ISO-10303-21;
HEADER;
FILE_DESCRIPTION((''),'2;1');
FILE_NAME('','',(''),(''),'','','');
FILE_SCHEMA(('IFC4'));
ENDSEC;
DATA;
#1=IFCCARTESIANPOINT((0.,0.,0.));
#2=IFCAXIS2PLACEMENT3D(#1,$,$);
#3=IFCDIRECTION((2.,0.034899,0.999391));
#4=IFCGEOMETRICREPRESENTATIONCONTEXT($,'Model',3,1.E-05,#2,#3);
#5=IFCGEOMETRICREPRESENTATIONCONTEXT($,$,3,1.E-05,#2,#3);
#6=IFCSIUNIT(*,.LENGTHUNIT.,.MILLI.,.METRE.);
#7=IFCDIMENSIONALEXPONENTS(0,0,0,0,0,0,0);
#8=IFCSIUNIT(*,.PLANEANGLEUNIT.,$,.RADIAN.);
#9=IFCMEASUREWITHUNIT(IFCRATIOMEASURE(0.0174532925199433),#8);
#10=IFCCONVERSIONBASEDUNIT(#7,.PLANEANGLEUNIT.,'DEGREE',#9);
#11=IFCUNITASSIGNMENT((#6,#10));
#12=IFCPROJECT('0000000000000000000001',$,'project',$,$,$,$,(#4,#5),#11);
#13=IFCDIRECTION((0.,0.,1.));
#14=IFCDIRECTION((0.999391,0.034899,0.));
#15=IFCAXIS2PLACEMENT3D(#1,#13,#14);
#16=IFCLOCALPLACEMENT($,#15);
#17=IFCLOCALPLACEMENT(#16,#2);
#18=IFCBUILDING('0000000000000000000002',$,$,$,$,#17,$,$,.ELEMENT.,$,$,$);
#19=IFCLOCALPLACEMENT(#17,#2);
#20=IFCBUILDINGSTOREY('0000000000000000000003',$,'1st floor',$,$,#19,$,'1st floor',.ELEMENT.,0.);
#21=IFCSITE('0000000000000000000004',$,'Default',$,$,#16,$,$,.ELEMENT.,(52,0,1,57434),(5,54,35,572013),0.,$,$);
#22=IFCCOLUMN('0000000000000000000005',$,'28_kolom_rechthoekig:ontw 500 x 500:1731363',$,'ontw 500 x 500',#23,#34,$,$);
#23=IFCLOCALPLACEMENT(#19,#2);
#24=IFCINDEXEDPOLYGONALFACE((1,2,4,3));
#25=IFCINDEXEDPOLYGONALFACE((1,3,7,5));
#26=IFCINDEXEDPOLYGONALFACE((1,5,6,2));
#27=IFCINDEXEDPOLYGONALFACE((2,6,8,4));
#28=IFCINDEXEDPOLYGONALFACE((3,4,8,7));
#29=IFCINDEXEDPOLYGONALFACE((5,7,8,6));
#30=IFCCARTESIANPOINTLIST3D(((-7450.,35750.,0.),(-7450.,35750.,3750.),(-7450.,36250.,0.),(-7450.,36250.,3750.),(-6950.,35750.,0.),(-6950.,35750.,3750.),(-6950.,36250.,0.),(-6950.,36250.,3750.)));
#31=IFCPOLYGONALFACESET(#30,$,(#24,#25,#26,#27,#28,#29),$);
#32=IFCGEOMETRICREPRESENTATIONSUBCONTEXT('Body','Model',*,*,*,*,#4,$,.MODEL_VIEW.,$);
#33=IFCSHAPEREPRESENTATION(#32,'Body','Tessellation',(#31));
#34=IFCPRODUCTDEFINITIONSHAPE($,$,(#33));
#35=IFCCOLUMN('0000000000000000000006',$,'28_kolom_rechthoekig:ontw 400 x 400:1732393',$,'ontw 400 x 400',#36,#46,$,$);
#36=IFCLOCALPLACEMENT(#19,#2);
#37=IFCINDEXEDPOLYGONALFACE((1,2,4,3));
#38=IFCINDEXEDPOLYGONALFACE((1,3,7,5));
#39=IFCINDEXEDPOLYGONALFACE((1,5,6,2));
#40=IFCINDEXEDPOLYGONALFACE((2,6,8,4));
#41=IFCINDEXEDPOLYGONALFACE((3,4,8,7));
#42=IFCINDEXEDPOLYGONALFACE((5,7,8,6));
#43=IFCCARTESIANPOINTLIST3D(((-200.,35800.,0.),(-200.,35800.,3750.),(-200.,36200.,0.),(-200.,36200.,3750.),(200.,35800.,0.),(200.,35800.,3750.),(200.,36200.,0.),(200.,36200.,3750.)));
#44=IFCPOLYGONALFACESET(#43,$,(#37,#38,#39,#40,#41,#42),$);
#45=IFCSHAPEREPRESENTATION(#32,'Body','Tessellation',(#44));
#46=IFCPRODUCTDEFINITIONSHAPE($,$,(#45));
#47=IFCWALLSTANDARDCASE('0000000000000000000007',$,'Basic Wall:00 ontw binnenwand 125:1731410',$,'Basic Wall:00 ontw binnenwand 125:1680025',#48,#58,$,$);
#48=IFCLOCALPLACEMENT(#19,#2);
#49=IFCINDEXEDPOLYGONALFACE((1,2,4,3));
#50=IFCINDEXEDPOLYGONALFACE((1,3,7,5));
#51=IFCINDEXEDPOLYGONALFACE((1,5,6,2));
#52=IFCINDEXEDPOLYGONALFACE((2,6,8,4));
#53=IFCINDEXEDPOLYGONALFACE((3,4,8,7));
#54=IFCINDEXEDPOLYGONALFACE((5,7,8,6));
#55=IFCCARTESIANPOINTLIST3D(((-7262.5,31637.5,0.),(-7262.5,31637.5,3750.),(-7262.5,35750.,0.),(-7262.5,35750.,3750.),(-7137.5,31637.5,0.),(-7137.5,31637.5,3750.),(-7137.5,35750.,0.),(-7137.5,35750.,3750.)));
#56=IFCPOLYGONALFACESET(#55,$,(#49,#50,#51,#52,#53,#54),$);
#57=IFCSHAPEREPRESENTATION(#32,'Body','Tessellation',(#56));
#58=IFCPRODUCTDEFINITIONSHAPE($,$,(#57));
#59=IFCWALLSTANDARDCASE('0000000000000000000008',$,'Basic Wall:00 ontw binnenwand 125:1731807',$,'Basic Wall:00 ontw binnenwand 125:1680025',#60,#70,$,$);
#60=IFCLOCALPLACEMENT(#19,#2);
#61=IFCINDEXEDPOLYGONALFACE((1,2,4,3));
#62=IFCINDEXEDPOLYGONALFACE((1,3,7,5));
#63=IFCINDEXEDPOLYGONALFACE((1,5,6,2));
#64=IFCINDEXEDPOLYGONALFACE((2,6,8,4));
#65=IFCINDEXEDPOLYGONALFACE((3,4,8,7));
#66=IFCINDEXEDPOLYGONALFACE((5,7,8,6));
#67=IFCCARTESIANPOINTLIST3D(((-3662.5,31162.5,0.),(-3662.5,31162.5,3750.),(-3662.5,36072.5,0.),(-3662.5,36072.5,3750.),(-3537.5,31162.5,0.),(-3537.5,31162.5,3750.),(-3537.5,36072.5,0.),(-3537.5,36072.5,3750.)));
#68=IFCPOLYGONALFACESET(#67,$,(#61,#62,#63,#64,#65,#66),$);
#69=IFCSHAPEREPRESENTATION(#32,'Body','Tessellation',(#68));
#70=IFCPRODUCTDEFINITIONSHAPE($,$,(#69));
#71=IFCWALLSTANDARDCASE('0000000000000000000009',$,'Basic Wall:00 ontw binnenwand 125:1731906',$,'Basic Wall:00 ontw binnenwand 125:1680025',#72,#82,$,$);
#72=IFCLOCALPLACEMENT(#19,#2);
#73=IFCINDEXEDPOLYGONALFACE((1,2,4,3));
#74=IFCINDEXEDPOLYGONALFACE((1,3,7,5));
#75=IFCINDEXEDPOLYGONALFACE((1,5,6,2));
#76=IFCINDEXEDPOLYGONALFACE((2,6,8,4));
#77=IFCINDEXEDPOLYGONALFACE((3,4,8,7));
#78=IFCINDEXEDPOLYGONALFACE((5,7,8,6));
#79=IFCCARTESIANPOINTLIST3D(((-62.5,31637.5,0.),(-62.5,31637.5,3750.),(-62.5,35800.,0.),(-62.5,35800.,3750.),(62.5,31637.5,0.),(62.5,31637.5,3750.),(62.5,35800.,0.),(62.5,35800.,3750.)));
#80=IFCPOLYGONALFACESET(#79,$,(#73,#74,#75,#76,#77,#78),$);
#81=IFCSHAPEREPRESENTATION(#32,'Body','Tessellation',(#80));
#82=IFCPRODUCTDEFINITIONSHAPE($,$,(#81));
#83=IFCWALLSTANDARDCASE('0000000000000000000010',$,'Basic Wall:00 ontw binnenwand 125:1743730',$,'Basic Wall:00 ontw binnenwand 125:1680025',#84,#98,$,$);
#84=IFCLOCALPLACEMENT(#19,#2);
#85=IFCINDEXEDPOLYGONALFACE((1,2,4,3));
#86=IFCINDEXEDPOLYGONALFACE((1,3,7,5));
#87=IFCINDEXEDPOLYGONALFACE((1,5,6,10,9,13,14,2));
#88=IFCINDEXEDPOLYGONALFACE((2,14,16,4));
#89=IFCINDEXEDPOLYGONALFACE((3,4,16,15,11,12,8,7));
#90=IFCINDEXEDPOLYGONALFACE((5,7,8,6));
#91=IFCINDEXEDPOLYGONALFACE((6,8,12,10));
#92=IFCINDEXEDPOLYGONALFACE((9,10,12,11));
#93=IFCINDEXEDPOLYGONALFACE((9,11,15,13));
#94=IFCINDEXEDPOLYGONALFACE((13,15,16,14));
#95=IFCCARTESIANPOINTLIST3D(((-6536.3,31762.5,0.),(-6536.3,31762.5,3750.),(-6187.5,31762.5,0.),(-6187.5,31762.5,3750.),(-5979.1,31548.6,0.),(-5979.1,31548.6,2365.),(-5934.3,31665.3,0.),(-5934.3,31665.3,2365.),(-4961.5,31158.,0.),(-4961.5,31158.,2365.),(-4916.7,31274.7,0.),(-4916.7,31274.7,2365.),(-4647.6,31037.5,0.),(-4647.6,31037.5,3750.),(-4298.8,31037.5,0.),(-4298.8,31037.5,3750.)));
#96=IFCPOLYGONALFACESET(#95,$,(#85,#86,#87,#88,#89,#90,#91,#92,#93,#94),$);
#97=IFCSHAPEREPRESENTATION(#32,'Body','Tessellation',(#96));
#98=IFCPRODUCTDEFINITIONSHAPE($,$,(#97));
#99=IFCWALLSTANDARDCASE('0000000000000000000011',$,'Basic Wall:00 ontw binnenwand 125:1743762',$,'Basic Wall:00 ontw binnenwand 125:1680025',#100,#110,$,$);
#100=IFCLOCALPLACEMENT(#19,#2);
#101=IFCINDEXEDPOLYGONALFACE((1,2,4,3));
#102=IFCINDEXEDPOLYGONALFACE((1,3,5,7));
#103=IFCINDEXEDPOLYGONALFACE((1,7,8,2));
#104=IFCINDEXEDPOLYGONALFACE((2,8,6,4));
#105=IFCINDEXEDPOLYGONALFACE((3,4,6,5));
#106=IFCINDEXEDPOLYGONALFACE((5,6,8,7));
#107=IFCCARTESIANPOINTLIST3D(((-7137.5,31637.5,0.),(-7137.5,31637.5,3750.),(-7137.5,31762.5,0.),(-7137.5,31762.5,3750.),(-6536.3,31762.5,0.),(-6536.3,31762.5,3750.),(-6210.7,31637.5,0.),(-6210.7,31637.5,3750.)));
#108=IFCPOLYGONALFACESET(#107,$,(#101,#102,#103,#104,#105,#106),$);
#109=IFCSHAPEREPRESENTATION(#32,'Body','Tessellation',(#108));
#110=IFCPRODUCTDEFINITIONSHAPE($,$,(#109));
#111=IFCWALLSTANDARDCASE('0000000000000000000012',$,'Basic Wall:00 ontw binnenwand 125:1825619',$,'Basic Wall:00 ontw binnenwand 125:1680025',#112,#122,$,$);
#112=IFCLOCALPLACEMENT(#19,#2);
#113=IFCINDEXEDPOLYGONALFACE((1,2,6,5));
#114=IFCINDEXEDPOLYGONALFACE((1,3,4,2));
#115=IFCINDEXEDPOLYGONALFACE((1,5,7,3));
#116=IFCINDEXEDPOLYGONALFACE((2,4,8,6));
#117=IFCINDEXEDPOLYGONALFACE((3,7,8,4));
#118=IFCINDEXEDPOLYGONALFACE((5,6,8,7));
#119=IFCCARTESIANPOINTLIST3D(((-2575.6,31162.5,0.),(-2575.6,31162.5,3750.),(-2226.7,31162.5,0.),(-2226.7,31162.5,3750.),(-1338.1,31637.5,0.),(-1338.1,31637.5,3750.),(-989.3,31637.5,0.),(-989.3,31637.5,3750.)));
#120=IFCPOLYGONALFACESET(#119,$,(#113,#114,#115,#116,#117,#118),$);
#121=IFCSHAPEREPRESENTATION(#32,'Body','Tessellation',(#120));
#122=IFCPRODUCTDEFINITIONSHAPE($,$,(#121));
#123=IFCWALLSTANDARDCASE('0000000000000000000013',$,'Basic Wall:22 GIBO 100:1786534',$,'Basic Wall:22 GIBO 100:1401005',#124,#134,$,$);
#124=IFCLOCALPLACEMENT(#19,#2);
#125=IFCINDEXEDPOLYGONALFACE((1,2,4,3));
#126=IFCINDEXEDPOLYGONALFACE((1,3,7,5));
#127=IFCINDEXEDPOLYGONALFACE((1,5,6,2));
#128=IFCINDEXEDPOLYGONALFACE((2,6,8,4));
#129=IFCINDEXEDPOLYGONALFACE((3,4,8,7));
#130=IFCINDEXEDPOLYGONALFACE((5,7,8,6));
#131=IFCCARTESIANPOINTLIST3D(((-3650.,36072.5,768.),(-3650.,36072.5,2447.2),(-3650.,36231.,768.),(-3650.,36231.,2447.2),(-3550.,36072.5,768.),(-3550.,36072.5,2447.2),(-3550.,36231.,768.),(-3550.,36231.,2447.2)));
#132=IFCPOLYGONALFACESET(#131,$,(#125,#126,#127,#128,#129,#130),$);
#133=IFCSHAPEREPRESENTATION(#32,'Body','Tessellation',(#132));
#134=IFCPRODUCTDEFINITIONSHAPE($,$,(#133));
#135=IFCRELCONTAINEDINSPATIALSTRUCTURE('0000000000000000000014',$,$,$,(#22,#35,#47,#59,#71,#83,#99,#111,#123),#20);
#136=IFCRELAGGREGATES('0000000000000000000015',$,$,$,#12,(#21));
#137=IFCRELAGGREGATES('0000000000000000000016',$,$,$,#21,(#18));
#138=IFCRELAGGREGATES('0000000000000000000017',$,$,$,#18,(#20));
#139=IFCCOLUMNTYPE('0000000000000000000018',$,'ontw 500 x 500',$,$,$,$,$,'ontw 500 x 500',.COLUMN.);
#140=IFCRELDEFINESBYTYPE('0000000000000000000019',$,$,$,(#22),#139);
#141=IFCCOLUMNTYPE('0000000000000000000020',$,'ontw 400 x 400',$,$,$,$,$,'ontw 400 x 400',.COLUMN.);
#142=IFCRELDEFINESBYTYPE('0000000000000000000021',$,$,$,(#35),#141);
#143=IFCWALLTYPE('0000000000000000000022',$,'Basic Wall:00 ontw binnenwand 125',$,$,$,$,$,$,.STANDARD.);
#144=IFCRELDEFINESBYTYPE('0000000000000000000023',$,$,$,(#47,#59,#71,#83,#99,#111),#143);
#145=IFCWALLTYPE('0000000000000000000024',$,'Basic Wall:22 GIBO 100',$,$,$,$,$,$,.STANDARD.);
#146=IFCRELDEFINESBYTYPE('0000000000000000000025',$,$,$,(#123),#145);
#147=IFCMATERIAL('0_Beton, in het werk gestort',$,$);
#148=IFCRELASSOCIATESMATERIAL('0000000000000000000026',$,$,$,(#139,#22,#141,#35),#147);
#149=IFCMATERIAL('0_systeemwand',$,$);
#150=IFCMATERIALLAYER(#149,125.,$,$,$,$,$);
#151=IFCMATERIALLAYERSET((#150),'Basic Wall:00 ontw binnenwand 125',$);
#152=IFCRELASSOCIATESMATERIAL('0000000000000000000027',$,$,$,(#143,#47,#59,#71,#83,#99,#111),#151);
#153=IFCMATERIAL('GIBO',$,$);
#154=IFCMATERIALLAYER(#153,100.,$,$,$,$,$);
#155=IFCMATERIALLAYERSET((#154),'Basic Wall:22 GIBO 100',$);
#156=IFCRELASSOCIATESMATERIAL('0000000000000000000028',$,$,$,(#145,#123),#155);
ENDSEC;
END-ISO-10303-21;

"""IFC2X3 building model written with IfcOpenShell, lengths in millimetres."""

from ifc_helpers import new_model, entity, si_unit, converted_unit, direction, frame, frame_2d, origin, place, context, subcontext, project, spatial, polyline, rectangle, outline, extrude, source, transform, mapped, material, layer, layer_set, layer_usage, type_object, type_shapes, element, save


model = new_model("IFC2X3")

# Units and contexts
model_context = context("Model", 3, precision=1e-05, world=origin(), true_north=direction((2.0, 0.034899, 0.999391)))
context_of_model = context(None, 3, precision=1e-05, world=origin(), true_north=direction((2.0, 0.034899, 0.999391)))
body_context = subcontext(model_context, "Body", "Model", "MODEL_VIEW")
ifc_project = project(units=[si_unit("LENGTHUNIT", "METRE", prefix="MILLI"), converted_unit("PLANEANGLEUNIT", "DEGREE", entity("IfcRatioMeasure", 0.0174532925199433), si_unit("PLANEANGLEUNIT", "RADIAN"), dimensions=[0, 0, 0, 0, 0, 0, 0])], contexts=[model_context, context_of_model])

# Site, building, storey
site_placement = place(None, frame((0.0, 0.0, 0.0), z_axis=(0.0, 0.0, 1.0), x_axis=(0.999391, 0.034899, 0.0)))
site = spatial("IfcSite", under=ifc_project, at=site_placement, Name="Default", CompositionType="ELEMENT", RefLatitude=(52, 0, 1, 57434), RefLongitude=(5, 54, 35, 572013), RefElevation=0.0)
building_placement = place(site_placement, origin())
building = spatial("IfcBuilding", under=site, at=building_placement, CompositionType="ELEMENT")
storey_placement = place(building_placement, origin())
storey = spatial("IfcBuildingStorey", under=building, at=storey_placement, Name="1st floor", LongName="1st floor", CompositionType="ELEMENT", Elevation=0.0)

# Columns
ifc_material_1 = material(Name="0_Beton, in het werk gestort")
column_type_1 = type_object("IfcColumnType", Name="ontw 500 x 500", ElementType="ontw 500 x 500", PredefinedType="COLUMN", material=ifc_material_1)
shared_shape_1 = source(origin(), body_context, "Body", "SweptSolid", [
    extrude(rectangle(XDim=500.0, YDim=500.0, at=frame_2d((0.0, 0.0), x_axis=(0.0, -1.0))), origin(), (0.0, 0.0, 1.0), 3750.0),
])
type_shapes(column_type_1, [shared_shape_1])
column_1_placement = place(storey_placement, frame((-7200.0, 36000.0, 0.0)))
element("IfcColumn", 1, at=column_1_placement, inside=storey, type_object=column_type_1, material=ifc_material_1, Name="28_kolom_rechthoekig:ontw 500 x 500:1731363", ObjectType="ontw 500 x 500", context=body_context, shape_type="MappedRepresentation", body=[
    mapped(shared_shape_1, transform((0.0, 0.0, 0.0), scale=1.0)),
])
column_type_2 = type_object("IfcColumnType", Name="ontw 400 x 400", ElementType="ontw 400 x 400", PredefinedType="COLUMN", material=ifc_material_1)
shared_shape_2 = source(origin(), body_context, "Body", "SweptSolid", [
    extrude(rectangle(XDim=400.0, YDim=400.0, at=frame_2d((0.0, 0.0), x_axis=(0.0, -1.0))), origin(), (0.0, 0.0, 1.0), 3750.0),
])
type_shapes(column_type_2, [shared_shape_2])
column_2_placement = place(storey_placement, frame((0.0, 36000.0, 0.0)))
element("IfcColumn", 2, at=column_2_placement, inside=storey, type_object=column_type_2, material=ifc_material_1, Name="28_kolom_rechthoekig:ontw 400 x 400:1732393", ObjectType="ontw 400 x 400", context=body_context, shape_type="MappedRepresentation", body=[
    mapped(shared_shape_2, transform((0.0, 0.0, 0.0), scale=1.0)),
])

# Walls
ifc_material_2 = material(Name="0_systeemwand")
ifc_layer_1 = layer(ifc_material_2, 125.0)
ifc_layer_set_1 = layer_set([ifc_layer_1], Name="Basic Wall:00 ontw binnenwand 125")
ifc_layer_usage_1 = layer_usage(ifc_layer_set_1, "AXIS2", "NEGATIVE", 62.5)
wall_type_1 = type_object("IfcWallType", Name="Basic Wall:00 ontw binnenwand 125", PredefinedType="STANDARD", material=ifc_layer_set_1)
wall_1_placement = place(storey_placement, frame((-7200.0, 35750.0, 0.0), z_axis=(0.0, 0.0, 1.0), x_axis=(0.0, -1.0, 0.0)))
element("IfcWallStandardCase", 3, at=wall_1_placement, inside=storey, type_object=wall_type_1, material=ifc_layer_usage_1, Name="Basic Wall:00 ontw binnenwand 125:1731410", ObjectType="Basic Wall:00 ontw binnenwand 125:1680025", context=body_context, shape_type="SweptSolid", body=[
    extrude(rectangle(XDim=4112.5, YDim=125.0, at=frame_2d((2056.2, 0.0), x_axis=(-1.0, 0.0))), origin(), (0.0, 0.0, 1.0), 3750.0),
])
ifc_layer_usage_2 = layer_usage(ifc_layer_set_1, "AXIS2", "NEGATIVE", 62.5)
wall_2_placement = place(storey_placement, frame((-3600.0, 31162.5, 0.0), z_axis=(0.0, 0.0, 1.0), x_axis=(0.0, 1.0, 0.0)))
element("IfcWallStandardCase", 4, at=wall_2_placement, inside=storey, type_object=wall_type_1, material=ifc_layer_usage_2, Name="Basic Wall:00 ontw binnenwand 125:1731807", ObjectType="Basic Wall:00 ontw binnenwand 125:1680025", context=body_context, shape_type="SweptSolid", body=[
    extrude(rectangle(XDim=4910.0, YDim=125.0, at=frame_2d((2455.0, 0.0), x_axis=(-1.0, 0.0))), origin(), (0.0, 0.0, 1.0), 3750.0),
])
ifc_layer_usage_3 = layer_usage(ifc_layer_set_1, "AXIS2", "NEGATIVE", 62.5)
wall_3_placement = place(storey_placement, frame((0.0, 31637.5, 0.0), z_axis=(0.0, 0.0, 1.0), x_axis=(0.0, 1.0, 0.0)))
element("IfcWallStandardCase", 5, at=wall_3_placement, inside=storey, type_object=wall_type_1, material=ifc_layer_usage_3, Name="Basic Wall:00 ontw binnenwand 125:1731906", ObjectType="Basic Wall:00 ontw binnenwand 125:1680025", context=body_context, shape_type="SweptSolid", body=[
    extrude(rectangle(XDim=4162.5, YDim=125.0, at=frame_2d((2081.2, 0.0), x_axis=(-1.0, 0.0))), origin(), (0.0, 0.0, 1.0), 3750.0),
])

# Wall, opening
ifc_layer_usage_4 = layer_usage(ifc_layer_set_1, "AXIS2", "NEGATIVE", 62.5)
wall_4_placement = place(storey_placement, frame((-6513.9, 31820.8, 0.0), z_axis=(0.0, 0.0, 1.0), x_axis=(0.93358, -0.358368, 0.0)))
wall_4 = element("IfcWallStandardCase", 6, at=wall_4_placement, inside=storey, type_object=wall_type_1, material=ifc_layer_usage_4, Name="Basic Wall:00 ontw binnenwand 125:1743730", ObjectType="Basic Wall:00 ontw binnenwand 125:1680025", context=body_context, shape_type="SweptSolid", body=[
    extrude(outline(polyline([(0.0, -62.5), (348.8, -62.5), (2023.1, -62.5), (2348.7, 62.5), (1999.9, 62.5), (325.6, 62.5), (0.0, -62.5)])), origin(), (0.0, 0.0, 1.0), 3750.0),
])
opening_1_placement = place(wall_4_placement, frame((596.8, -62.5, 0.0)))
element("IfcOpeningElement", 7, at=opening_1_placement, cuts=wall_4, ObjectType="Opening", context=body_context, shape_type="SweptSolid", body=[
    extrude(rectangle(XDim=2365.0, YDim=1090.0, at=frame_2d((1182.5, 545.0), x_axis=(1.0, 0.0))), frame((0.0, 0.0, 0.0), z_axis=(0.0, 1.0, 0.0), x_axis=(0.0, 0.0, 1.0)), (0.0, 0.0, 1.0), 125.0),
])

# Walls
ifc_layer_usage_5 = layer_usage(ifc_layer_set_1, "AXIS2", "POSITIVE", -62.5)
wall_5_placement = place(storey_placement, frame((-6210.7, 31700.0, 0.0), z_axis=(0.0, 0.0, 1.0), x_axis=(-1.0, 0.0, 0.0)))
element("IfcWallStandardCase", 8, at=wall_5_placement, inside=storey, type_object=wall_type_1, material=ifc_layer_usage_5, Name="Basic Wall:00 ontw binnenwand 125:1743762", ObjectType="Basic Wall:00 ontw binnenwand 125:1680025", context=body_context, shape_type="SweptSolid", body=[
    extrude(outline(polyline([(926.8, -62.5), (926.8, 62.5), (0.0, 62.5), (325.6, -62.5), (926.8, -62.5)])), origin(), (0.0, 0.0, 1.0), 3750.0),
])
ifc_layer_usage_6 = layer_usage(ifc_layer_set_1, "AXIS2", "POSITIVE", -62.5)
wall_6_placement = place(storey_placement, frame((-1011.7, 31695.8, 0.0), z_axis=(0.0, 0.0, 1.0), x_axis=(-0.93358, -0.358368, 0.0)))
element("IfcWallStandardCase", 9, at=wall_6_placement, inside=storey, type_object=wall_type_1, material=ifc_layer_usage_6, Name="Basic Wall:00 ontw binnenwand 125:1825619", ObjectType="Basic Wall:00 ontw binnenwand 125:1680025", context=body_context, shape_type="SweptSolid", body=[
    extrude(outline(polyline([(325.6, -62.5), (1651.1, -62.5), (1325.5, 62.5), (0.0, 62.5), (325.6, -62.5)])), origin(), (0.0, 0.0, 1.0), 3750.0),
])
ifc_material_3 = material(Name="GIBO")
ifc_layer_2 = layer(ifc_material_3, 100.0)
ifc_layer_set_2 = layer_set([ifc_layer_2], Name="Basic Wall:22 GIBO 100")
ifc_layer_usage_7 = layer_usage(ifc_layer_set_2, "AXIS2", "NEGATIVE", 50.0)
wall_type_2 = type_object("IfcWallType", Name="Basic Wall:22 GIBO 100", PredefinedType="STANDARD", material=ifc_layer_set_2)
wall_7_placement = place(storey_placement, frame((-3600.0, 36072.5, 768.0), z_axis=(0.0, 0.0, 1.0), x_axis=(0.0, 1.0, 0.0)))
element("IfcWallStandardCase", 10, at=wall_7_placement, inside=storey, type_object=wall_type_2, material=ifc_layer_usage_7, Name="Basic Wall:22 GIBO 100:1786534", ObjectType="Basic Wall:22 GIBO 100:1401005", context=body_context, shape_type="SweptSolid", body=[
    extrude(rectangle(XDim=158.5, YDim=100.0, at=frame_2d((79.2, 0.0), x_axis=(-1.0, 0.0))), origin(), (0.0, 0.0, 1.0), 1679.2),
])

save(model, "model.ifc")
